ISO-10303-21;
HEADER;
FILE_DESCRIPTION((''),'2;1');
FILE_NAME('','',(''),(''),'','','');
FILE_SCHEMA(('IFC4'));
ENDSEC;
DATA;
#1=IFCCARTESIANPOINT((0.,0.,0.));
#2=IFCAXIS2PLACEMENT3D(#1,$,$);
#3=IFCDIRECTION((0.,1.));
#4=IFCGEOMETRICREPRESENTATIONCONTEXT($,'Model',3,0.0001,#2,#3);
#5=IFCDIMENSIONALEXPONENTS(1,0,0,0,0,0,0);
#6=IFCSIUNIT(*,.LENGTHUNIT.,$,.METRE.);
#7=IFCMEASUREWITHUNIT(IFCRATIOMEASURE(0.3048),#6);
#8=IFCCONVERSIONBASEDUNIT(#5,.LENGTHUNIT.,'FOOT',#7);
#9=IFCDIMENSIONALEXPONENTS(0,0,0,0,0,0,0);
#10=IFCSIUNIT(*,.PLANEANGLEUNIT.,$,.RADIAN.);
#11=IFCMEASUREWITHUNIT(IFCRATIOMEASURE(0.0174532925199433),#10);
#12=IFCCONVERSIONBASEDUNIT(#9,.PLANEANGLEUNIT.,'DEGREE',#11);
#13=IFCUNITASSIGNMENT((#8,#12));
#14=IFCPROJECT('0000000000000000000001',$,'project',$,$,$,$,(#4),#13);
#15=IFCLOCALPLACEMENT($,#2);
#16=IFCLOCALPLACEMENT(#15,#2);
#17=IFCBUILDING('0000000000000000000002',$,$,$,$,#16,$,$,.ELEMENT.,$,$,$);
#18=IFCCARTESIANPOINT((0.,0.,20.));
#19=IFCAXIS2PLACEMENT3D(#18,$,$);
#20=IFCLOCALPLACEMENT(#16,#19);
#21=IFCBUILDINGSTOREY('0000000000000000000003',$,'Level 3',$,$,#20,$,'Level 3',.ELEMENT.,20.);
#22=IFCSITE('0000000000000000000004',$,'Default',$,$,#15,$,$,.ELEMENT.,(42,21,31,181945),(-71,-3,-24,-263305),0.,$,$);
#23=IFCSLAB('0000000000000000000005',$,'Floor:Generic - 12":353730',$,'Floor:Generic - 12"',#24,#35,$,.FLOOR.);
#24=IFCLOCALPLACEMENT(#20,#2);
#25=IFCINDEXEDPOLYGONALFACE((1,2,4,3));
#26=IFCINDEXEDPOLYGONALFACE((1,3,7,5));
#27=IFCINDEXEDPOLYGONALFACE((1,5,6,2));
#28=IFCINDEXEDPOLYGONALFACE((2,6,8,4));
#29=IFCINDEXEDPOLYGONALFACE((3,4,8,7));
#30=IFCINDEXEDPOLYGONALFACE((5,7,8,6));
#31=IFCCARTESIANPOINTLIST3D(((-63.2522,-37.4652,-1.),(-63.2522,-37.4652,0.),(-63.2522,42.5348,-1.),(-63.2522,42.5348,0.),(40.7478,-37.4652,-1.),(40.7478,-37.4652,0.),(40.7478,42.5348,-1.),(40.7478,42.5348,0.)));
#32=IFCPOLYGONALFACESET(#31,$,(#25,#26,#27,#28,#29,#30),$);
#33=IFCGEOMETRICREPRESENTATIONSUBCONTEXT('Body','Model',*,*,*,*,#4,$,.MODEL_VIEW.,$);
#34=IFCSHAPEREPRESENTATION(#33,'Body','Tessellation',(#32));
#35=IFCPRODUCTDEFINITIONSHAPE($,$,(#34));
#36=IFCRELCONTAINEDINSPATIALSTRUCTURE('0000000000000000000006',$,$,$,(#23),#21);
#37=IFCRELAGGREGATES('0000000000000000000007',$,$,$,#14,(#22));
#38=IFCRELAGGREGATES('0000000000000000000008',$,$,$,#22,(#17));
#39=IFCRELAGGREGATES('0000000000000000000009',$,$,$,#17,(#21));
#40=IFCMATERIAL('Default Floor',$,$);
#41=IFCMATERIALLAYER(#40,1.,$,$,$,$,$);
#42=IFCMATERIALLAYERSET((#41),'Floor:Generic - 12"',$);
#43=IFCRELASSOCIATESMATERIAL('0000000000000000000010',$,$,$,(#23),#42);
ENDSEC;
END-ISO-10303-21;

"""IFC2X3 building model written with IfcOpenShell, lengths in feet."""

from ifc_helpers import new_model, entity, si_unit, converted_unit, direction, frame, origin, origin_2d_with_axis, place, context, subcontext, project, spatial, rectangle, extrude, material, layer, layer_set, layer_usage, element, save


model = new_model("IFC2X3")

# Units and contexts
model_context = context("Model", 3, precision=0.0001, world=origin(), true_north=direction((0.0, 1.0)))
body_context = subcontext(model_context, "Body", "Model", "MODEL_VIEW")
ifc_project = project(units=[converted_unit("LENGTHUNIT", "FOOT", entity("IfcRatioMeasure", 0.3048), si_unit("LENGTHUNIT", "METRE"), dimensions=[1, 0, 0, 0, 0, 0, 0]), converted_unit("PLANEANGLEUNIT", "DEGREE", entity("IfcRatioMeasure", 0.0174532925199433), si_unit("PLANEANGLEUNIT", "RADIAN"), dimensions=[0, 0, 0, 0, 0, 0, 0])], contexts=[model_context])

# Site, building, storey
site_placement = place(None, origin())
site = spatial("IfcSite", under=ifc_project, at=site_placement, Name="Default", CompositionType="ELEMENT", RefLatitude=(42, 21, 31, 181945), RefLongitude=(-71, -3, -24, -263305), RefElevation=0.0)
building_placement = place(site_placement, origin())
building = spatial("IfcBuilding", under=site, at=building_placement, CompositionType="ELEMENT")
storey_placement = place(building_placement, frame((0.0, 0.0, 20.0)))
storey = spatial("IfcBuildingStorey", under=building, at=storey_placement, Name="Level 3", LongName="Level 3", CompositionType="ELEMENT", Elevation=20.0)

# Slab
ifc_material = material(Name="Default Floor")
ifc_layer = layer(ifc_material, 1.0)
ifc_layer_set = layer_set([ifc_layer], Name="Floor:Generic - 12\"")
ifc_layer_usage = layer_usage(ifc_layer_set, "AXIS3", "POSITIVE", 0.0)
slab_placement = place(storey_placement, origin())
element("IfcSlab", 1, at=slab_placement, inside=storey, material=ifc_layer_usage, Name="Floor:Generic - 12\":353730", ObjectType="Floor:Generic - 12\"", PredefinedType="FLOOR", context=body_context, shape_type="SweptSolid", body=[
    extrude(rectangle(XDim=80.0, YDim=104.0, at=origin_2d_with_axis()), frame((-11.2522, 2.5348, 0.0), z_axis=(0.0, 0.0, -1.0), x_axis=(0.0, 1.0, 0.0)), (0.0, 0.0, 1.0), 1.0),
])

save(model, "model.ifc")
